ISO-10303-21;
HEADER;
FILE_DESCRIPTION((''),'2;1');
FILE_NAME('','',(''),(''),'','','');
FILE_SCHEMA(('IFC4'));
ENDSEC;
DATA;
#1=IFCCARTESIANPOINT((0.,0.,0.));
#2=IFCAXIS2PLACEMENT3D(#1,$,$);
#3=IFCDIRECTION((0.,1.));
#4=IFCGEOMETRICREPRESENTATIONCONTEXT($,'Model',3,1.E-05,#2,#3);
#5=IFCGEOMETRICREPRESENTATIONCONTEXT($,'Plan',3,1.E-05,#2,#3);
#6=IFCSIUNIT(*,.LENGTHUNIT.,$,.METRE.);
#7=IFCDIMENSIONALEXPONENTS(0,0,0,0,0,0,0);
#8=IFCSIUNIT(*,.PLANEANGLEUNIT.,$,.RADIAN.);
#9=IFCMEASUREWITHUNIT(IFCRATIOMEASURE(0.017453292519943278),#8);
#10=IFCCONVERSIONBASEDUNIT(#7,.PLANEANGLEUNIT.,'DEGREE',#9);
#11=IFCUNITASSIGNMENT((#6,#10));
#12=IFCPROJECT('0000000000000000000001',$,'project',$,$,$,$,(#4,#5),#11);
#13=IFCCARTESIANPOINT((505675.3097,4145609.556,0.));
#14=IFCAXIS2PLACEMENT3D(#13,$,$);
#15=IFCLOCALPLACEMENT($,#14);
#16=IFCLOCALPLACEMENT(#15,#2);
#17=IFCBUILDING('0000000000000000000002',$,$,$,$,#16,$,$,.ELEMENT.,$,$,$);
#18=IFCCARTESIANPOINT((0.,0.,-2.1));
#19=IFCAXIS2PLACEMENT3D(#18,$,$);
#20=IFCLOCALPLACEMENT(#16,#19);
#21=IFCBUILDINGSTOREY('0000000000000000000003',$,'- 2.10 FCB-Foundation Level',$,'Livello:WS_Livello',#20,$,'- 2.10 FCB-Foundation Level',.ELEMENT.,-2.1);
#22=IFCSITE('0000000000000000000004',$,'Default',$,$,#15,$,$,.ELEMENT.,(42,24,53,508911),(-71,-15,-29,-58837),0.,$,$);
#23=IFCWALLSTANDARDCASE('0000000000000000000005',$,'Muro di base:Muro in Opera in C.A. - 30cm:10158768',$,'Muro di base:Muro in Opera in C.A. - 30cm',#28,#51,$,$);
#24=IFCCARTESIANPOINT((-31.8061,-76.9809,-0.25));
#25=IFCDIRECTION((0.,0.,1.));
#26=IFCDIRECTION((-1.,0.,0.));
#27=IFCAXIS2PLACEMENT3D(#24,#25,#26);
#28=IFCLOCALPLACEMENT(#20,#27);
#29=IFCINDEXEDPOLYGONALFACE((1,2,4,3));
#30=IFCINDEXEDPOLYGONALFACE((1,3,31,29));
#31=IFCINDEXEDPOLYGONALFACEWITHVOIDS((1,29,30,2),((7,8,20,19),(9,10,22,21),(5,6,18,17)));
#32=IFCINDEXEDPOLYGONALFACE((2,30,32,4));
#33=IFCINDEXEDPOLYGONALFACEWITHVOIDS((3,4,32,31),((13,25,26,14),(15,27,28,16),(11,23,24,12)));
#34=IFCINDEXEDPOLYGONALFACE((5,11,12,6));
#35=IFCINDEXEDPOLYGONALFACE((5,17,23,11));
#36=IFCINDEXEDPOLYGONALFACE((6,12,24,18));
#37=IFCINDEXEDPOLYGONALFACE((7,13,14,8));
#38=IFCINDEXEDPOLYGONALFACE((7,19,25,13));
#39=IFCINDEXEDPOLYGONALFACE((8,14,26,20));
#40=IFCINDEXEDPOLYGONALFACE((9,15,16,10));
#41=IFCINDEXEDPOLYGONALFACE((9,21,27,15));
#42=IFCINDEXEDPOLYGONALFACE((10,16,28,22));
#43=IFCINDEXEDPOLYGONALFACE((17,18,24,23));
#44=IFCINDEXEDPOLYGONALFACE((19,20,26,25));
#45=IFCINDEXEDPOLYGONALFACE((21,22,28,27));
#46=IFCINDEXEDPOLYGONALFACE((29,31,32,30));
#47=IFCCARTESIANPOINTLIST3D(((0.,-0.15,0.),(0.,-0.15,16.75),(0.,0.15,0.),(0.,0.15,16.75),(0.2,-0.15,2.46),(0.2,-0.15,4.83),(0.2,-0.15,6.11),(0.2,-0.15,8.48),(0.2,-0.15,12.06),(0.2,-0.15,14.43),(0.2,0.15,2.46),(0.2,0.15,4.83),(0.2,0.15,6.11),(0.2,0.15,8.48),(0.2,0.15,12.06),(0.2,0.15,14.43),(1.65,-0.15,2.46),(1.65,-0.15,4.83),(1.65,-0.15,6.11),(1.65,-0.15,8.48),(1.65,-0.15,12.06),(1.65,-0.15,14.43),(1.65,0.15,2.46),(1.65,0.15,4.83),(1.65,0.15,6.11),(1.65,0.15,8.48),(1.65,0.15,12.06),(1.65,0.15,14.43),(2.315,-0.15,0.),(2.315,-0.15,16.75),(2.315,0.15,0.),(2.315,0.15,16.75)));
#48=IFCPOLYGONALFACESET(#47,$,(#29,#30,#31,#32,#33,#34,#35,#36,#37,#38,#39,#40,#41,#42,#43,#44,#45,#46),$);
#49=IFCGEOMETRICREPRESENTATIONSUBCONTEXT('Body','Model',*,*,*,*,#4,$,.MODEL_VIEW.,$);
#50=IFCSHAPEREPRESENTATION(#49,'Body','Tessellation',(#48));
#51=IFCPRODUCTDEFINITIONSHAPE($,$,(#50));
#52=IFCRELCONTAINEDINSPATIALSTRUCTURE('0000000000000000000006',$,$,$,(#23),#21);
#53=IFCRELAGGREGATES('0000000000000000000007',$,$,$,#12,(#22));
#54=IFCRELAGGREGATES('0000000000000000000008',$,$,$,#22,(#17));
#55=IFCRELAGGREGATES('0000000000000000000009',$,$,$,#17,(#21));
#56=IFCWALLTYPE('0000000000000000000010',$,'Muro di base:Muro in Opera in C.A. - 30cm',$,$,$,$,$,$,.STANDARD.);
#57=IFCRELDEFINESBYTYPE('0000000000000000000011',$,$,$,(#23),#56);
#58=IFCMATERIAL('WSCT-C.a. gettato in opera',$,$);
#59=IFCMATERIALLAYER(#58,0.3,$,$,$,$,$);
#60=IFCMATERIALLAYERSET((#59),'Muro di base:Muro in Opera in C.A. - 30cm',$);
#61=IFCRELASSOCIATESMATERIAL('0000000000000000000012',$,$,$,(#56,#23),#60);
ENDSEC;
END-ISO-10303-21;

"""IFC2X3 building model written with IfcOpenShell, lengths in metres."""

from ifc_helpers import new_model, entity, si_unit, converted_unit, direction, frame, frame_2d, origin, origin_2d_with_axis, place, context, subcontext, project, spatial, polyline, rectangle, extrude, clip, bounded_halfspace, material, layer, layer_set, layer_usage, type_object, element, save


model = new_model("IFC2X3")

# Units and contexts
model_context = context("Model", 3, precision=1e-05, world=origin(), true_north=direction((0.0, 1.0)))
plan_context = context("Plan", 3, precision=1e-05, world=origin(), true_north=direction((0.0, 1.0)))
body_context = subcontext(model_context, "Body", "Model", "MODEL_VIEW")
ifc_project = project(units=[si_unit("LENGTHUNIT", "METRE"), converted_unit("PLANEANGLEUNIT", "DEGREE", entity("IfcRatioMeasure", 0.017453292519943278), si_unit("PLANEANGLEUNIT", "RADIAN"), dimensions=[0, 0, 0, 0, 0, 0, 0])], contexts=[model_context, plan_context])

# Site, building, storey
site_placement = place(None, frame((505675.3097, 4145609.556, 0.0)))
site = spatial("IfcSite", under=ifc_project, at=site_placement, Name="Default", CompositionType="ELEMENT", RefLatitude=(42, 24, 53, 508911), RefLongitude=(-71, -15, -29, -58837), RefElevation=0.0)
building_placement = place(site_placement, origin())
building = spatial("IfcBuilding", under=site, at=building_placement, CompositionType="ELEMENT")
storey_placement = place(building_placement, frame((0.0, 0.0, -2.1)))
storey = spatial("IfcBuildingStorey", under=building, at=storey_placement, Name="- 2.10 FCB-Foundation Level", ObjectType="Livello:WS_Livello", LongName="- 2.10 FCB-Foundation Level", CompositionType="ELEMENT", Elevation=-2.1)

# Shared definitions
ifc_material = material(Name="WSCT-C.a. gettato in opera")
ifc_layer_1 = layer(ifc_material, 0.3)
ifc_layer_set_1 = layer_set([ifc_layer_1], Name="Muro di base:Muro in Opera in C.A. - 30cm")
ifc_layer_usage_1 = layer_usage(ifc_layer_set_1, "AXIS2", "NEGATIVE", 0.15)
wall_type_1 = type_object("IfcWallType", Name="Muro di base:Muro in Opera in C.A. - 30cm", PredefinedType="STANDARD", material=ifc_layer_set_1)

# Wall, openings
wall_1_placement = place(storey_placement, frame((-31.8061, -76.9809, -0.25), z_axis=(0.0, 0.0, 1.0), x_axis=(-1.0, 0.0, 0.0)))
wall_1 = element("IfcWallStandardCase", 1, at=wall_1_placement, inside=storey, type_object=wall_type_1, material=ifc_layer_usage_1, Name="Muro di base:Muro in Opera in C.A. - 30cm:10158768", ObjectType="Muro di base:Muro in Opera in C.A. - 30cm", context=body_context, shape_type="Clipping", body=[
    clip(extrude(rectangle(XDim=2.315, YDim=0.3, at=frame_2d((1.1575, 0.0), x_axis=(-1.0, 0.0))), origin(), (0.0, 0.0, 1.0), 16.75), bounded_halfspace(frame((2.315, -0.145, 16.75), z_axis=(0.0, 0.0, -1.0), x_axis=(0.0, 1.0, 0.0)), True, frame((2.315, -0.145, 16.75)), polyline([(0.0, 0.0), (0.0, 0.295), (-2.315, 0.295), (-2.315, 0.0), (0.0, 0.0)]))),
])
opening_1_placement = place(wall_1_placement, origin())
element("IfcOpeningElement", 2, at=opening_1_placement, cuts=wall_1, ObjectType="Opening", context=body_context, shape_type="SweptSolid", body=[
    extrude(rectangle(XDim=2.37, YDim=1.45, at=origin_2d_with_axis()), frame((0.925, -0.15, 3.645), z_axis=(0.0, 1.0, 0.0), x_axis=(0.0, 0.0, -1.0)), (0.0, 0.0, 1.0), 0.3),
])
opening_2_placement = place(wall_1_placement, origin())
element("IfcOpeningElement", 3, at=opening_2_placement, cuts=wall_1, ObjectType="Opening", context=body_context, shape_type="SweptSolid", body=[
    extrude(rectangle(XDim=2.37, YDim=1.45, at=frame_2d((0.0, 0.0), x_axis=(1.0, 0.0))), frame((0.925, -0.15, 7.295), z_axis=(0.0, 1.0, 0.0), x_axis=(0.0, 0.0, -1.0)), (0.0, 0.0, 1.0), 0.3),
])
opening_3_placement = place(wall_1_placement, origin())
element("IfcOpeningElement", 4, at=opening_3_placement, cuts=wall_1, ObjectType="Opening", context=body_context, shape_type="SweptSolid", body=[
    extrude(rectangle(XDim=2.37, YDim=1.45, at=frame_2d((0.0, 0.0), x_axis=(1.0, 0.0))), frame((0.925, -0.15, 13.245), z_axis=(0.0, 1.0, 0.0), x_axis=(0.0, 0.0, -1.0)), (0.0, 0.0, 1.0), 0.3),
])

save(model, "model.ifc")
